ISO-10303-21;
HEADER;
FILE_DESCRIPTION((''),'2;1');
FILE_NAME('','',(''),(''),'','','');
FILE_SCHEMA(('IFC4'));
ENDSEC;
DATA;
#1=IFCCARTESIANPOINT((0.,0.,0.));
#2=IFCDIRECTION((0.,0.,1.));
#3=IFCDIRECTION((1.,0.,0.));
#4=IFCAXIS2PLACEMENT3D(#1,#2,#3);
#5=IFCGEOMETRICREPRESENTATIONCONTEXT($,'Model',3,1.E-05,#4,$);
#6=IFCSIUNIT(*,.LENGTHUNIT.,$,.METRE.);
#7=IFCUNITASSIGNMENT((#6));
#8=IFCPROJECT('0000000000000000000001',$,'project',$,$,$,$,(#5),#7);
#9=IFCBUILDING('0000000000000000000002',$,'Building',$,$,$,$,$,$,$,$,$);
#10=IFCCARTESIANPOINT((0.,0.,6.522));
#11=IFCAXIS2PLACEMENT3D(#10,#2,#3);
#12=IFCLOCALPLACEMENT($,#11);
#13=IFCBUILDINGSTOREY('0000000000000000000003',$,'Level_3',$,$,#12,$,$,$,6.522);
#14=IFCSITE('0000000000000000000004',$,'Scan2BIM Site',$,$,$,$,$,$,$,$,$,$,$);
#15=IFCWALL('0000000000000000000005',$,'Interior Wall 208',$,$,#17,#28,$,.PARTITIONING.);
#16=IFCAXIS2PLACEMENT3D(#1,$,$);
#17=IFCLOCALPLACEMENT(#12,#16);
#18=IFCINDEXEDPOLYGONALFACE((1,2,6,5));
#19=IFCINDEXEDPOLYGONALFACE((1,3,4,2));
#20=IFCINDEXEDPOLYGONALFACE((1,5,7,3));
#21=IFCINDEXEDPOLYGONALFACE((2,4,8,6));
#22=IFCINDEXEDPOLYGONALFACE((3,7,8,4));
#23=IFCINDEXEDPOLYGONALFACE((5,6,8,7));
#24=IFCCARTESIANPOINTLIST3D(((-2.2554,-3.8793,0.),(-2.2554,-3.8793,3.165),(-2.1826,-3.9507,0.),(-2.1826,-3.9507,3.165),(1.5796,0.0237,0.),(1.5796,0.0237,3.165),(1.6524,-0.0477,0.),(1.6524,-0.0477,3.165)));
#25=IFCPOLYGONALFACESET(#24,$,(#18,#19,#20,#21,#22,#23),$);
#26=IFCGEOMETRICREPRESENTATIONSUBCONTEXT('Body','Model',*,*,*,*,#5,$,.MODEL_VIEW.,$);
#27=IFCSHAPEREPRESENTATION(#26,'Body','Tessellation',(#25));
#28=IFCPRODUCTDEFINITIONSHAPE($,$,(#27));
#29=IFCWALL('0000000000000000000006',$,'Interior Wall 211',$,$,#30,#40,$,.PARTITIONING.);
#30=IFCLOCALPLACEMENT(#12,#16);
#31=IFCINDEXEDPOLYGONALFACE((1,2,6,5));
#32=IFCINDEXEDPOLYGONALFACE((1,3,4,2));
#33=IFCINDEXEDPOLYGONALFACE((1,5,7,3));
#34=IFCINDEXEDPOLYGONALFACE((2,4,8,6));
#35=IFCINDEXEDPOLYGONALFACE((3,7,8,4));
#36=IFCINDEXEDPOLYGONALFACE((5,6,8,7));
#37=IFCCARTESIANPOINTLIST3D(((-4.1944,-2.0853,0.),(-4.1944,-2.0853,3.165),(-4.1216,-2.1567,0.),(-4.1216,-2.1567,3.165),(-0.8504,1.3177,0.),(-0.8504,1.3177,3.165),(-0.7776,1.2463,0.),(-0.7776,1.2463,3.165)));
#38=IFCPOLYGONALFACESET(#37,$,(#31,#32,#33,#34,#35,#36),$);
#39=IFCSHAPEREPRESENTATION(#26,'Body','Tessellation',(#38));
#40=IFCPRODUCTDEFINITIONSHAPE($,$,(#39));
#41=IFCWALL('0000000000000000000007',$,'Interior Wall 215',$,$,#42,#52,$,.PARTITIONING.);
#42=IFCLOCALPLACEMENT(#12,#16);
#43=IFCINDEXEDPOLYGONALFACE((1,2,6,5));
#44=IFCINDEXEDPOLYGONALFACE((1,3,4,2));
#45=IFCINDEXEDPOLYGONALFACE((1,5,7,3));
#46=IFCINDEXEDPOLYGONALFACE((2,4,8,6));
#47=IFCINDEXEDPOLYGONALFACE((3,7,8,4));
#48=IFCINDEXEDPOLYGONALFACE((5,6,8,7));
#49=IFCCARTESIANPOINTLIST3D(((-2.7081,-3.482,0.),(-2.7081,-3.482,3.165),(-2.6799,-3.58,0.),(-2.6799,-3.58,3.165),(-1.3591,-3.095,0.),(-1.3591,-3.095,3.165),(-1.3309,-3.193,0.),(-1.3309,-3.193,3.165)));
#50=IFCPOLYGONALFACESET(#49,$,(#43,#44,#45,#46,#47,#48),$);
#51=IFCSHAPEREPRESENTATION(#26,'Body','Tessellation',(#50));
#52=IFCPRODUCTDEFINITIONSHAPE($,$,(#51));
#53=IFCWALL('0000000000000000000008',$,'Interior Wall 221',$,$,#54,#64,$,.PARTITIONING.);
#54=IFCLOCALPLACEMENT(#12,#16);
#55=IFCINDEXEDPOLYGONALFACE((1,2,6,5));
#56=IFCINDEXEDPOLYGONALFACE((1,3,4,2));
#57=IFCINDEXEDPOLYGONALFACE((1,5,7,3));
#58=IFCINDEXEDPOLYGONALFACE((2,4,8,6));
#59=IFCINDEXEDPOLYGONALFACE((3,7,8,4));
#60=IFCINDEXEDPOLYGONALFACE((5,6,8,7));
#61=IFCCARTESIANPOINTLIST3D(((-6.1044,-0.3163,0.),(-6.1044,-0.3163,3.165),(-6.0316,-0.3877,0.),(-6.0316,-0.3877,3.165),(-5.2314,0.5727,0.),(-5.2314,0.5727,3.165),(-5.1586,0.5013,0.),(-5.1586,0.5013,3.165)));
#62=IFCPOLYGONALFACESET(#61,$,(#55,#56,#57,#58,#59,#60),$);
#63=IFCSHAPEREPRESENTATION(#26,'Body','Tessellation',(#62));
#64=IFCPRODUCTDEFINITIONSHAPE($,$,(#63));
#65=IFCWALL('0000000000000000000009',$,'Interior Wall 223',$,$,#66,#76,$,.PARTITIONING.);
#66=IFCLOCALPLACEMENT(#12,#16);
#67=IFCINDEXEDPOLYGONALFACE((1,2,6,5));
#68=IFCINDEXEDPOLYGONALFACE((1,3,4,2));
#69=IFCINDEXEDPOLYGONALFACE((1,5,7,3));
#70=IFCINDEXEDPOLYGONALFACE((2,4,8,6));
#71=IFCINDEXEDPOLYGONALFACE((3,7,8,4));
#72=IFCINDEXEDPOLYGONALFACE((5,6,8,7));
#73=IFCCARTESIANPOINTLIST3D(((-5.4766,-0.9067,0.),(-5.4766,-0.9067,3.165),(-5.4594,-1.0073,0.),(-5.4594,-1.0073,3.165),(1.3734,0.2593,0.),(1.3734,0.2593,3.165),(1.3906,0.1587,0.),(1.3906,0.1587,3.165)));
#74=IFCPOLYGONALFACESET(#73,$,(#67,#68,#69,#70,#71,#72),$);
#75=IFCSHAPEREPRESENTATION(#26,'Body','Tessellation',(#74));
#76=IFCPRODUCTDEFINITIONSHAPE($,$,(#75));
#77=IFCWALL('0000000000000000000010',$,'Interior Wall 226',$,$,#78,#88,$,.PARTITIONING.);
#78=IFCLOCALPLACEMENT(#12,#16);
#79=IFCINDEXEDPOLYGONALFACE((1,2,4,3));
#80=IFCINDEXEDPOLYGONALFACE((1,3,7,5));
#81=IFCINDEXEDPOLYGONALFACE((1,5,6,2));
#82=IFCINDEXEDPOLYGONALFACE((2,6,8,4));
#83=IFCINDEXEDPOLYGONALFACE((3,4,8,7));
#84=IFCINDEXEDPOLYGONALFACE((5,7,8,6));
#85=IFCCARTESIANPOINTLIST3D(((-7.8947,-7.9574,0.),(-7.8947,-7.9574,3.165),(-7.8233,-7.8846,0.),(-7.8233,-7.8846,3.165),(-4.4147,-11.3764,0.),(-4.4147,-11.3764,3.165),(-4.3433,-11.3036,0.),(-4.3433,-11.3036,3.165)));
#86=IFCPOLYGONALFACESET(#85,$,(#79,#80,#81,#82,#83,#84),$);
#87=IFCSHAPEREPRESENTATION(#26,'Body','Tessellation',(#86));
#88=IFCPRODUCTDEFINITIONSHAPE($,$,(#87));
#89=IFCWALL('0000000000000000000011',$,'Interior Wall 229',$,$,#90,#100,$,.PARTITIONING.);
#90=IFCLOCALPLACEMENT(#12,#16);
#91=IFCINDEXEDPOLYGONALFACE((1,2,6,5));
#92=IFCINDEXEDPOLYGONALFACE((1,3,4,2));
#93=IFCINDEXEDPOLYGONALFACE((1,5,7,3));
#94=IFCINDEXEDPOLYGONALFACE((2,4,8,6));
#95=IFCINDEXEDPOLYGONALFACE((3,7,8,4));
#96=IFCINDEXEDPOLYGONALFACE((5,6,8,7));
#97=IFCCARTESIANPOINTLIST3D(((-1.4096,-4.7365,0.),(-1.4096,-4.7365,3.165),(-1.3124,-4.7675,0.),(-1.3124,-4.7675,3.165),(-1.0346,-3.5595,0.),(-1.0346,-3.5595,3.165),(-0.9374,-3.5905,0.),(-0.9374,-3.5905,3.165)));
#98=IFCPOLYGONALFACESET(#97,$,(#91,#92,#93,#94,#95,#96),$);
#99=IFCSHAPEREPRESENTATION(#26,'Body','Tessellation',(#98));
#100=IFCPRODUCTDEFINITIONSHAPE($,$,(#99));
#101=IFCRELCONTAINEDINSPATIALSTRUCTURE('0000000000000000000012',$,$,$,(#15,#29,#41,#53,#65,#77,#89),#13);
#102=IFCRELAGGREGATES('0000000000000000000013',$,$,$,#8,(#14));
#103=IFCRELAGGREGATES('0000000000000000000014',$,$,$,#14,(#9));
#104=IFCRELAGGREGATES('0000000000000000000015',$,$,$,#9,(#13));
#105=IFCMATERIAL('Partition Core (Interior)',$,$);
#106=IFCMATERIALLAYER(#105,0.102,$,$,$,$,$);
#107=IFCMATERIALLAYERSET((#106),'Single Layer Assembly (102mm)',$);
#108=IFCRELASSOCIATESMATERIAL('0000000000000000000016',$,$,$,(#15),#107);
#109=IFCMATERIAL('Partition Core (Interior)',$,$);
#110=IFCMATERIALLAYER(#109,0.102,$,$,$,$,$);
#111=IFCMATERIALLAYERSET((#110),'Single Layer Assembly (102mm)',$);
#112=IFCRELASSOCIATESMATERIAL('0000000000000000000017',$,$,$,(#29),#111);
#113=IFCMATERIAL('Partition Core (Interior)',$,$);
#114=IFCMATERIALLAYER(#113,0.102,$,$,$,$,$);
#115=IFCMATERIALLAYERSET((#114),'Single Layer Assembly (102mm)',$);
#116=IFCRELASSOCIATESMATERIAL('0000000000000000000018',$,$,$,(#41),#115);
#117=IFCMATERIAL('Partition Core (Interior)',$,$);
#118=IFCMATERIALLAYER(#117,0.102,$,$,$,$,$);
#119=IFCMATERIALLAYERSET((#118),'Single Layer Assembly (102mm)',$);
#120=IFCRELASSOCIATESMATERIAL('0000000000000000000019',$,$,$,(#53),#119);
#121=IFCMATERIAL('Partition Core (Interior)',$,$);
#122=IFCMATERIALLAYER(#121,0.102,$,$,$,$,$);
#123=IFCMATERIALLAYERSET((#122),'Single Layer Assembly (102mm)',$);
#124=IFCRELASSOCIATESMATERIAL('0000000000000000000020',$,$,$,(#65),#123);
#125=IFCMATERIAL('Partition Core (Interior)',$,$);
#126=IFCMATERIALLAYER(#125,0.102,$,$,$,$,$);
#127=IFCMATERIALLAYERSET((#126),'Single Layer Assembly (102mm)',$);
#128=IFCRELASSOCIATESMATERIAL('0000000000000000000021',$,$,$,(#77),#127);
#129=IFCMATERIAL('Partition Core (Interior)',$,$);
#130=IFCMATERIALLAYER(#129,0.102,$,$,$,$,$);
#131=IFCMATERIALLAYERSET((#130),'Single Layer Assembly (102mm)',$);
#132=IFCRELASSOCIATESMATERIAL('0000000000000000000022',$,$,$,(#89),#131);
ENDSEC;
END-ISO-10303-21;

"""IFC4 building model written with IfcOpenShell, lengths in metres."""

from ifc_helpers import new_model, si_unit, frame, origin, origin_with_axes, place, context, subcontext, project, spatial, rectangle, extrude, material, layer, layer_set, element, save


model = new_model("IFC4")

# Units and contexts
model_context = context("Model", 3, precision=1e-05, world=origin_with_axes())
body_context = subcontext(model_context, "Body", "Model", "MODEL_VIEW")
ifc_project = project(units=[si_unit("LENGTHUNIT", "METRE")], contexts=[model_context])

# Site, building, storey
site = spatial("IfcSite", under=ifc_project, Name="Scan2BIM Site")
building = spatial("IfcBuilding", under=site, Name="Building")
storey_placement = place(None, frame((0.0, 0.0, 6.522), z_axis=(0.0, 0.0, 1.0), x_axis=(1.0, 0.0, 0.0)))
storey = spatial("IfcBuildingStorey", under=building, at=storey_placement, Name="Level_3", Elevation=6.522)

# Walls
ifc_material_1 = material(Name="Partition Core (Interior)")
ifc_layer_1 = layer(ifc_material_1, 0.102)
ifc_layer_set_1 = layer_set([ifc_layer_1], Name="Single Layer Assembly (102mm)")
wall_1_placement = place(storey_placement, frame((-0.3015, -1.9635, 0.0), z_axis=(0.0, 0.0, 1.0), x_axis=(-0.700866, -0.713293, 0.0)))
element("IfcWall", 1, at=wall_1_placement, inside=storey, material=ifc_layer_set_1, Name="Interior Wall 208", PredefinedType="PARTITIONING", context=body_context, shape_type="SweptSolid", body=[
    extrude(rectangle(XDim=5.4718, YDim=0.102), origin(), (0.0, 0.0, 1.0), 3.165),
])
ifc_material_2 = material(Name="Partition Core (Interior)")
ifc_layer_2 = layer(ifc_material_2, 0.102)
ifc_layer_set_2 = layer_set([ifc_layer_2], Name="Single Layer Assembly (102mm)")
wall_2_placement = place(storey_placement, frame((-2.486, -0.4195, 0.0), z_axis=(0.0, 0.0, 1.0), x_axis=(-0.700897, -0.713263, 0.0)))
element("IfcWall", 2, at=wall_2_placement, inside=storey, material=ifc_layer_set_2, Name="Interior Wall 211", PredefinedType="PARTITIONING", context=body_context, shape_type="SweptSolid", body=[
    extrude(rectangle(XDim=4.771, YDim=0.102), origin(), (0.0, 0.0, 1.0), 3.165),
])
ifc_material_3 = material(Name="Partition Core (Interior)")
ifc_layer_3 = layer(ifc_material_3, 0.102)
ifc_layer_set_3 = layer_set([ifc_layer_3], Name="Single Layer Assembly (102mm)")
wall_3_placement = place(storey_placement, frame((-2.0195, -3.3375, 0.0), z_axis=(0.0, 0.0, 1.0), x_axis=(0.961228, 0.275756, 0.0)))
element("IfcWall", 3, at=wall_3_placement, inside=storey, material=ifc_layer_set_3, Name="Interior Wall 215", PredefinedType="PARTITIONING", context=body_context, shape_type="SweptSolid", body=[
    extrude(rectangle(XDim=1.4034, YDim=0.102), origin(), (0.0, 0.0, 1.0), 3.165),
])
ifc_material_4 = material(Name="Partition Core (Interior)")
ifc_layer_4 = layer(ifc_material_4, 0.102)
ifc_layer_set_4 = layer_set([ifc_layer_4], Name="Single Layer Assembly (102mm)")
wall_4_placement = place(storey_placement, frame((-5.6315, 0.0925, 0.0), z_axis=(0.0, 0.0, 1.0), x_axis=(-0.700657, -0.713498, 0.0)))
element("IfcWall", 4, at=wall_4_placement, inside=storey, material=ifc_layer_set_4, Name="Interior Wall 221", PredefinedType="PARTITIONING", context=body_context, shape_type="SweptSolid", body=[
    extrude(rectangle(XDim=1.246, YDim=0.102), origin(), (0.0, 0.0, 1.0), 3.165),
])
ifc_material_5 = material(Name="Partition Core (Interior)")
ifc_layer_5 = layer(ifc_material_5, 0.102)
ifc_layer_set_5 = layer_set([ifc_layer_5], Name="Single Layer Assembly (102mm)")
wall_5_placement = place(storey_placement, frame((-2.043, -0.374, 0.0), z_axis=(0.0, 0.0, 1.0), x_axis=(-0.98582, -0.167805, 0.0)))
element("IfcWall", 5, at=wall_5_placement, inside=storey, material=ifc_layer_set_5, Name="Interior Wall 223", PredefinedType="PARTITIONING", context=body_context, shape_type="SweptSolid", body=[
    extrude(rectangle(XDim=6.9485, YDim=0.102), origin(), (0.0, 0.0, 1.0), 3.165),
])
ifc_material_6 = material(Name="Partition Core (Interior)")
ifc_layer_6 = layer(ifc_material_6, 0.102)
ifc_layer_set_6 = layer_set([ifc_layer_6], Name="Single Layer Assembly (102mm)")
wall_6_placement = place(storey_placement, frame((-6.119, -9.6305, 0.0), z_axis=(0.0, 0.0, 1.0), x_axis=(-0.713331, 0.700827, 0.0)))
element("IfcWall", 6, at=wall_6_placement, inside=storey, material=ifc_layer_set_6, Name="Interior Wall 226", PredefinedType="PARTITIONING", context=body_context, shape_type="SweptSolid", body=[
    extrude(rectangle(XDim=4.8785, YDim=0.102), origin(), (0.0, 0.0, 1.0), 3.165),
])
ifc_material_7 = material(Name="Partition Core (Interior)")
ifc_layer_7 = layer(ifc_material_7, 0.102)
ifc_layer_set_7 = layer_set([ifc_layer_7], Name="Single Layer Assembly (102mm)")
wall_7_placement = place(storey_placement, frame((-1.1735, -4.1635, 0.0), z_axis=(0.0, 0.0, 1.0), x_axis=(-0.303571, -0.952809, 0.0)))
element("IfcWall", 7, at=wall_7_placement, inside=storey, material=ifc_layer_set_7, Name="Interior Wall 229", PredefinedType="PARTITIONING", context=body_context, shape_type="SweptSolid", body=[
    extrude(rectangle(XDim=1.2353, YDim=0.102), origin(), (0.0, 0.0, 1.0), 3.165),
])

save(model, "model.ifc")
